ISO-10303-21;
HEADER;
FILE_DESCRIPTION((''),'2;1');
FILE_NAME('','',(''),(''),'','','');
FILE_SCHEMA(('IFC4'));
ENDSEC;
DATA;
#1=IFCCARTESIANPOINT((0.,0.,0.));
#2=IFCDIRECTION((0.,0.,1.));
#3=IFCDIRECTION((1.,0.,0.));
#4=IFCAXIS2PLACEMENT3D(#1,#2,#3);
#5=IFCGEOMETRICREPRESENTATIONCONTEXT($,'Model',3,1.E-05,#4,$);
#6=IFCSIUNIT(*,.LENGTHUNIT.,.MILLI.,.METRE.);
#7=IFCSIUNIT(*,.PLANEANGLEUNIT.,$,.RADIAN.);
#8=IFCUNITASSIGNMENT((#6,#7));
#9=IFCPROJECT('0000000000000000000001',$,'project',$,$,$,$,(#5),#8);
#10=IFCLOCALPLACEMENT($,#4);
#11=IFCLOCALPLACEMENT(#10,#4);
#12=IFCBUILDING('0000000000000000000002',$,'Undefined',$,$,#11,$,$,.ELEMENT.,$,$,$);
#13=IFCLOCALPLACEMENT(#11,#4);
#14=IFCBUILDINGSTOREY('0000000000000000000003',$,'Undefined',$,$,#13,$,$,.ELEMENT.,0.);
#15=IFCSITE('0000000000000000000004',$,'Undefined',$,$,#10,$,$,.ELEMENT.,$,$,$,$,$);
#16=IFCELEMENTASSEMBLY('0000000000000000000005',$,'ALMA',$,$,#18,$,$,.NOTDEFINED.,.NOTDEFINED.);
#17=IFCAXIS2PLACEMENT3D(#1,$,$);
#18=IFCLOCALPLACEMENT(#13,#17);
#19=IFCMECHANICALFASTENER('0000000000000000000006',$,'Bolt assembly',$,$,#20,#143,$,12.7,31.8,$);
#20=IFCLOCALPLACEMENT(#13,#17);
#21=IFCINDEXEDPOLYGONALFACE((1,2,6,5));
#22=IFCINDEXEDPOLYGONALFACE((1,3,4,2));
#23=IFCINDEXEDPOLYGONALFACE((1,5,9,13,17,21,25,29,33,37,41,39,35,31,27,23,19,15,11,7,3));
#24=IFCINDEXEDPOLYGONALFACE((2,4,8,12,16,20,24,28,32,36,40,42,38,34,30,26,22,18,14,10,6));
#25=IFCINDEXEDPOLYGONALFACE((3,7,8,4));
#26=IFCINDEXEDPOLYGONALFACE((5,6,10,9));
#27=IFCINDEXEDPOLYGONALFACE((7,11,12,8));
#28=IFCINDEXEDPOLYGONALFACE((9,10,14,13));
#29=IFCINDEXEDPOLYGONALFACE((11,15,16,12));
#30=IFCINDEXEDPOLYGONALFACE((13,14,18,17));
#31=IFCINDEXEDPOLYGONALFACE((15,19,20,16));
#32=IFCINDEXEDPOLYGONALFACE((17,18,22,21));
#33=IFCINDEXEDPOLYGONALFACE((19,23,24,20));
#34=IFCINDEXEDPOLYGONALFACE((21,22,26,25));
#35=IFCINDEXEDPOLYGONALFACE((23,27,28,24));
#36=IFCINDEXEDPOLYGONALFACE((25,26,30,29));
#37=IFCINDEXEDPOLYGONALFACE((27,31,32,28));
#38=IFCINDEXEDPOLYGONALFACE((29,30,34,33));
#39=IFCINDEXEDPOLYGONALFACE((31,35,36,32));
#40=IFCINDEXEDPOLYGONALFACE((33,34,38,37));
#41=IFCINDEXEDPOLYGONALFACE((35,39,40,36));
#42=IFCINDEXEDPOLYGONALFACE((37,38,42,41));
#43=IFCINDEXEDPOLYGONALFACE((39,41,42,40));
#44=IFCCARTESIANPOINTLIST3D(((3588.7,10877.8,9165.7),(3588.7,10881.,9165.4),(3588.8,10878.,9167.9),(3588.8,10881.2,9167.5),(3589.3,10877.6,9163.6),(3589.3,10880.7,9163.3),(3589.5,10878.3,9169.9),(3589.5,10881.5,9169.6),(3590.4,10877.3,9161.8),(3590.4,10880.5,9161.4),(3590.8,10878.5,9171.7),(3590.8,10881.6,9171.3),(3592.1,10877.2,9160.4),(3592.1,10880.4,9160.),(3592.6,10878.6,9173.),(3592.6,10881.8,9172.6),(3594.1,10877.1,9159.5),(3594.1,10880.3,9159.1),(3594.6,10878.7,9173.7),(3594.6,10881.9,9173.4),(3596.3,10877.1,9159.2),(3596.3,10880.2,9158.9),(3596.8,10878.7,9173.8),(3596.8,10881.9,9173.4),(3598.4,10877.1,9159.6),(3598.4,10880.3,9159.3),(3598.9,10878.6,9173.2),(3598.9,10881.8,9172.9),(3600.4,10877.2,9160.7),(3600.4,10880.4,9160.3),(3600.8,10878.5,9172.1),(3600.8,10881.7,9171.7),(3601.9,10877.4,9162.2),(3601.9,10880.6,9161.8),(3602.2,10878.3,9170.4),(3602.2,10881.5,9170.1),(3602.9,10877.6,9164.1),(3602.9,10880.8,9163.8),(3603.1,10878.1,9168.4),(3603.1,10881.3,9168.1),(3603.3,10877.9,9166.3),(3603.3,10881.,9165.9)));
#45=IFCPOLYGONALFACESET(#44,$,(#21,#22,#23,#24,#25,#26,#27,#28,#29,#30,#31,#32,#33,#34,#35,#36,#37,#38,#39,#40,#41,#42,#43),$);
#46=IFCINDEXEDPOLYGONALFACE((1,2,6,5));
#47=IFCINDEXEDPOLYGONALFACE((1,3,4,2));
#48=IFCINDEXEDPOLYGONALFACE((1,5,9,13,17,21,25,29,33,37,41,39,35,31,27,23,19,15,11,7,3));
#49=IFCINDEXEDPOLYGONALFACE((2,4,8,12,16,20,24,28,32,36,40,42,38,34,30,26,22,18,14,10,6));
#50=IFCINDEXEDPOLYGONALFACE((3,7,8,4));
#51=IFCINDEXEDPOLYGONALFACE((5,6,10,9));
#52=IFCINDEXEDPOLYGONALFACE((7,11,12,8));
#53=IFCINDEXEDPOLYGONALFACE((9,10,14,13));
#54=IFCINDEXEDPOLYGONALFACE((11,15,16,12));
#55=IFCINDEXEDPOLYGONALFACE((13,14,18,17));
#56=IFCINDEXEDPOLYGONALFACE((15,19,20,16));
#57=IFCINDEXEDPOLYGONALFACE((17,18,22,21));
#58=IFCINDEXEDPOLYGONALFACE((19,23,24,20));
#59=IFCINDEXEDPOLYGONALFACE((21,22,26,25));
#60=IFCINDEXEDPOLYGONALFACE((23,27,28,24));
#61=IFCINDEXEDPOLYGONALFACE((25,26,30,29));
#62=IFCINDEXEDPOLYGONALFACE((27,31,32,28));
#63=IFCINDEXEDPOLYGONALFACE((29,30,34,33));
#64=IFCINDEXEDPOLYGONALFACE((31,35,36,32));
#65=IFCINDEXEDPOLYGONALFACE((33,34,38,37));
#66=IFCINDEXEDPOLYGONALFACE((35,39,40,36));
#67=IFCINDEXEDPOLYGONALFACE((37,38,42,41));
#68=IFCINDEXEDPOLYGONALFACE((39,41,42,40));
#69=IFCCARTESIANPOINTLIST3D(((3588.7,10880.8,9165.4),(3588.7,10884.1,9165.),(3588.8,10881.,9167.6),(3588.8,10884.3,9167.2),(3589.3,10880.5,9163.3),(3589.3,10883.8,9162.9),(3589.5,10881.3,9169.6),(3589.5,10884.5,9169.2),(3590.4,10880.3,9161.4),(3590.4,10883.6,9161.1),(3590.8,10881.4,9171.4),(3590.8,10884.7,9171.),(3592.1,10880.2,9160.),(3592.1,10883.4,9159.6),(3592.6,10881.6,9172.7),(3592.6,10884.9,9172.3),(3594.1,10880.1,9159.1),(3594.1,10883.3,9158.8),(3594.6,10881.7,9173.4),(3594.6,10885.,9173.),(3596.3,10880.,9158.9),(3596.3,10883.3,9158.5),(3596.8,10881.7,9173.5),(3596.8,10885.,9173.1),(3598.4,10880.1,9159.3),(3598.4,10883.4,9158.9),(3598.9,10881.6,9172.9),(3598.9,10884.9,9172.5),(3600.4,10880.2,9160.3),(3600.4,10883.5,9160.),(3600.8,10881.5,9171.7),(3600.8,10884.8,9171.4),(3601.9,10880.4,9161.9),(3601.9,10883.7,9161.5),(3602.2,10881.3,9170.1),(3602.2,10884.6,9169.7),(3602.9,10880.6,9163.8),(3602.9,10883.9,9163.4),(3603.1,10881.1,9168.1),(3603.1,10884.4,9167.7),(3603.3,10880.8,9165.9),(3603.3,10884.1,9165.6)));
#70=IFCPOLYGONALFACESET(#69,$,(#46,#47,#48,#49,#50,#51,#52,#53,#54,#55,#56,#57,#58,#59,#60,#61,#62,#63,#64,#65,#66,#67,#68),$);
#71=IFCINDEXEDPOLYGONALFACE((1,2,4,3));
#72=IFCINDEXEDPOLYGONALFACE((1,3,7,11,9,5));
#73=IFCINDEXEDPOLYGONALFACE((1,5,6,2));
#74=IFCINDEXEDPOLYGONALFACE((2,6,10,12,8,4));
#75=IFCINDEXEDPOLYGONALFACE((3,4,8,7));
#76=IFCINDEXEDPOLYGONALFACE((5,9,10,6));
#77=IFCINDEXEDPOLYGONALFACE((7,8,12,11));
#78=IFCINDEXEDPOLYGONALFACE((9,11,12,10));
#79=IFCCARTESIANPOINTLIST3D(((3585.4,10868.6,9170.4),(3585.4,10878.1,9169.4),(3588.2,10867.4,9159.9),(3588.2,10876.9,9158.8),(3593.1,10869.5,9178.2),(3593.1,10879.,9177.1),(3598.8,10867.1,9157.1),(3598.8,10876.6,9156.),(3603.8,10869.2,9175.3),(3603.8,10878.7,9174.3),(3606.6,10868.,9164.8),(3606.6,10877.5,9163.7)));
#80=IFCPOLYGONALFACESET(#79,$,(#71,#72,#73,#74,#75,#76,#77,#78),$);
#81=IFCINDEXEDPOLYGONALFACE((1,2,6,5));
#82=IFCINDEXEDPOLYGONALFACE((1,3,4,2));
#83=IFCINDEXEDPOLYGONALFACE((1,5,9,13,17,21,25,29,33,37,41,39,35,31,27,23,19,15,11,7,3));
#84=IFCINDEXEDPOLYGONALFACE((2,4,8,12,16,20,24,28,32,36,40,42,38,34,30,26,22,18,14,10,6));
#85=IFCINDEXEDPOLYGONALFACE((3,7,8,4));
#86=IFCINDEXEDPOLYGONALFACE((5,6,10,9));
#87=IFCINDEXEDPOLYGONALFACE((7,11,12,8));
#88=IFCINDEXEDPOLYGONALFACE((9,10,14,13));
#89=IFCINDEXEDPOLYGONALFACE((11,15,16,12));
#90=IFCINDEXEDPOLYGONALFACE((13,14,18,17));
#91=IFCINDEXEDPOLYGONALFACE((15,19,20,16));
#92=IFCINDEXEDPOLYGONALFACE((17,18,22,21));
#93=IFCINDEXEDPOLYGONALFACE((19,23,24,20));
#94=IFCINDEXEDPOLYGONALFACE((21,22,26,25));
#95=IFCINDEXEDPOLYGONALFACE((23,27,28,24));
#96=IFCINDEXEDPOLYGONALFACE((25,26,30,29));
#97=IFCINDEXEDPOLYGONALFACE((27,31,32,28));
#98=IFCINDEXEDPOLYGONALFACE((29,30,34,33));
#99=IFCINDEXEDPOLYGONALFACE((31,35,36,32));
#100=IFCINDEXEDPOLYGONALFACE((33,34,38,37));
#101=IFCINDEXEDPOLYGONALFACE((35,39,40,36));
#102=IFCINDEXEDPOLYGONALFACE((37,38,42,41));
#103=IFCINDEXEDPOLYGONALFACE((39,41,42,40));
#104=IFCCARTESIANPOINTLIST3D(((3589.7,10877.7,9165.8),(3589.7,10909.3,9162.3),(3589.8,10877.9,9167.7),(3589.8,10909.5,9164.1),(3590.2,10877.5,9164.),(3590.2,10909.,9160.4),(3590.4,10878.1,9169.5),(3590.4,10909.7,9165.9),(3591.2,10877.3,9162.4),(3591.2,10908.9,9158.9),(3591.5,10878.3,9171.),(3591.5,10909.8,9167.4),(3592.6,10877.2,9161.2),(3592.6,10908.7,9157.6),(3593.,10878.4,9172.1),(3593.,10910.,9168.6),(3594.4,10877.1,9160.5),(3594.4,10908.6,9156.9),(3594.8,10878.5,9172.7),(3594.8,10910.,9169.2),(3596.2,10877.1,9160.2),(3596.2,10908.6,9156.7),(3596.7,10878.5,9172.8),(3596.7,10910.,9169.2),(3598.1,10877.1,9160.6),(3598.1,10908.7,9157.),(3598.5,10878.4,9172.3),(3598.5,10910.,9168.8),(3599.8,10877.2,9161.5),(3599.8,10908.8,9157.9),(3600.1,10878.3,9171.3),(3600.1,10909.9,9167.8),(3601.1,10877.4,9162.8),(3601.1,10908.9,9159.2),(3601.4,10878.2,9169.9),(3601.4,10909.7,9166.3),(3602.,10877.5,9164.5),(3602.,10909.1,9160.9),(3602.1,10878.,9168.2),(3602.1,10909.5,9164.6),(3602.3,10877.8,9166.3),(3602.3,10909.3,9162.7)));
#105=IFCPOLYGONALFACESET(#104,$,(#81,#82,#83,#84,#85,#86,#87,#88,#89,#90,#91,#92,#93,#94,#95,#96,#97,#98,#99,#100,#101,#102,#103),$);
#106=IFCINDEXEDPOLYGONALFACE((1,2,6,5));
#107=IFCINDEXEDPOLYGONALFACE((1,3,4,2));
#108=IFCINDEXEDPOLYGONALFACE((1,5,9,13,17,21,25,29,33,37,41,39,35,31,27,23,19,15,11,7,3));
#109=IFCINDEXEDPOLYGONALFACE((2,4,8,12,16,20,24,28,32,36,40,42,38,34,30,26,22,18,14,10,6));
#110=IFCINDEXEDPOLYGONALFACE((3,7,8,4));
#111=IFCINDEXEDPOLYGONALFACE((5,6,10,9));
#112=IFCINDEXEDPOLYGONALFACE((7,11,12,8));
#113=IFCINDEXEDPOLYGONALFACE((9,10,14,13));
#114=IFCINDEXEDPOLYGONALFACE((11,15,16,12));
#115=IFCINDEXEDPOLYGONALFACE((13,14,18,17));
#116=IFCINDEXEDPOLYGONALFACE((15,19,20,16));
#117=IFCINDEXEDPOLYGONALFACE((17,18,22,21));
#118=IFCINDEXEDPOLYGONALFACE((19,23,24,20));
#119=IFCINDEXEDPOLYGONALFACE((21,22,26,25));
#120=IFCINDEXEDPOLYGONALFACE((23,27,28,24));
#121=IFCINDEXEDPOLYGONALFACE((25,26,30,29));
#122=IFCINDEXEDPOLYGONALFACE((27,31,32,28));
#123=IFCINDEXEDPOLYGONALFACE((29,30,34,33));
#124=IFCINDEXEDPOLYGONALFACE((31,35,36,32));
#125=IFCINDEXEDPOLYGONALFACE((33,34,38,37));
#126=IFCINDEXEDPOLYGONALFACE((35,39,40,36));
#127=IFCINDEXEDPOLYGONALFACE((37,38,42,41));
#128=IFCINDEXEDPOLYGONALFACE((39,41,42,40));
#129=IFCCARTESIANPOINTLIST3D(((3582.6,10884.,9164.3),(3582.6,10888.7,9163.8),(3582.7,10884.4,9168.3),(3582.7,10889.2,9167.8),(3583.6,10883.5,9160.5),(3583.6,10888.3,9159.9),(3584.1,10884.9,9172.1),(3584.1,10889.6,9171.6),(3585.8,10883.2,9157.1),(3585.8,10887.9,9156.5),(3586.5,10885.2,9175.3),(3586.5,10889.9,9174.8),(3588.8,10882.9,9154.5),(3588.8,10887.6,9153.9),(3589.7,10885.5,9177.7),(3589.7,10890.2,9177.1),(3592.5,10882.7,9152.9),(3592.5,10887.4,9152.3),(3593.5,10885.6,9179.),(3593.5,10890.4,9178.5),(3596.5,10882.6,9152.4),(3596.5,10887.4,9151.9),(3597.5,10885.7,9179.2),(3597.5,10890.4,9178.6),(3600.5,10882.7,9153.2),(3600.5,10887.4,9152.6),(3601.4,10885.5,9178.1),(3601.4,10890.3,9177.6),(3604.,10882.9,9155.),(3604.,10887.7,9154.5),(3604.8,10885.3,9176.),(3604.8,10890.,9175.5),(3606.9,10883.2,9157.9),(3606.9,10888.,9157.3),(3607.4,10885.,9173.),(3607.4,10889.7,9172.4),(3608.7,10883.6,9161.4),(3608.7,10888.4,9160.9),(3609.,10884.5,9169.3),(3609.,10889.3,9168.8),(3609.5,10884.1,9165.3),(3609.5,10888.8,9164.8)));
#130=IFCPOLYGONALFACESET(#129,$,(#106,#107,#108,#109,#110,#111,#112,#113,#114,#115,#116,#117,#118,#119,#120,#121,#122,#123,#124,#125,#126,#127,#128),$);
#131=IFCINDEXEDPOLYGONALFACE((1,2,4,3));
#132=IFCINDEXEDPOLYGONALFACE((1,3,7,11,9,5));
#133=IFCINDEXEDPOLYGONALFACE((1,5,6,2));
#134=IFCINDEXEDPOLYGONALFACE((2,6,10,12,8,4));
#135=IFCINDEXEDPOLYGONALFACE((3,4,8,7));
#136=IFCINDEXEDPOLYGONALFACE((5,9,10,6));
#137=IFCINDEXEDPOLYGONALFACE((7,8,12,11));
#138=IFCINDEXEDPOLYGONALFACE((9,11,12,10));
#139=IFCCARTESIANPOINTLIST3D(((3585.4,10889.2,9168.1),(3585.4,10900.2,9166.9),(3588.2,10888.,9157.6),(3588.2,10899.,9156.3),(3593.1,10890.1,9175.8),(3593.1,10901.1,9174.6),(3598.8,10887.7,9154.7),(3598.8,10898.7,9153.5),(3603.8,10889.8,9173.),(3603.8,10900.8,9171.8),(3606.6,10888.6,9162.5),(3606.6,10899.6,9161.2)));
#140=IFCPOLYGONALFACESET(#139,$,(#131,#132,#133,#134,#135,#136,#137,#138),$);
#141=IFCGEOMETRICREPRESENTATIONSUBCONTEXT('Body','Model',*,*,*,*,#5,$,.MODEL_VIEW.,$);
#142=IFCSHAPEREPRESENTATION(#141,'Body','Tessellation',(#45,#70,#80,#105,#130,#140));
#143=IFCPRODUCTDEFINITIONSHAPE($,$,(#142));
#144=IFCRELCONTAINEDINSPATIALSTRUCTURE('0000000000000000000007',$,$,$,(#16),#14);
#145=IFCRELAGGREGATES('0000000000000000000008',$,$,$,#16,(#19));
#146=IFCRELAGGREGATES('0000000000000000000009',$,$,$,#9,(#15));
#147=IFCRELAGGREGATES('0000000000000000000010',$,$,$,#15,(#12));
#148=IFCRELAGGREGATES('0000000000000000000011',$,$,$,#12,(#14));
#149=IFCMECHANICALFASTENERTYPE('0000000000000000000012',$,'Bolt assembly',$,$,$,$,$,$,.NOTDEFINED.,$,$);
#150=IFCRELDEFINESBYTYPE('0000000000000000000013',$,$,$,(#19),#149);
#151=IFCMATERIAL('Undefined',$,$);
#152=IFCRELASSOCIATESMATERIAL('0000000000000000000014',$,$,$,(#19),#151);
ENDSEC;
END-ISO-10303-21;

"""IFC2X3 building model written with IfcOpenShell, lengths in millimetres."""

from ifc_helpers import new_model, si_unit, frame, origin_with_axes, origin_2d_with_axis, place, context, subcontext, project, spatial, polyline, circle, outline, extrude, source, transform, mapped, material, type_object, element, aggregate, save


model = new_model("IFC2X3")

# Units and contexts
model_context = context("Model", 3, precision=1e-05, world=origin_with_axes())
body_context = subcontext(model_context, "Body", "Model", "MODEL_VIEW")
ifc_project = project(units=[si_unit("LENGTHUNIT", "METRE", prefix="MILLI"), si_unit("PLANEANGLEUNIT", "RADIAN")], contexts=[model_context])

# Site, building, storey
site_placement = place(None, origin_with_axes())
site = spatial("IfcSite", under=ifc_project, at=site_placement, Name="Undefined", CompositionType="ELEMENT")
building_placement = place(site_placement, origin_with_axes())
building = spatial("IfcBuilding", under=site, at=building_placement, Name="Undefined", CompositionType="ELEMENT")
storey_placement = place(building_placement, origin_with_axes())
storey = spatial("IfcBuildingStorey", under=building, at=storey_placement, Name="Undefined", CompositionType="ELEMENT", Elevation=0.0)

# Element assembly
assembly_1_placement = place(storey_placement, origin_with_axes())
assembly_1 = element("IfcElementAssembly", 1, at=assembly_1_placement, inside=storey, Name="ALMA", AssemblyPlace="NOTDEFINED", PredefinedType="NOTDEFINED")

# Mechanical fastener
ifc_material_1 = material(Name="Undefined")
mechanical_fastener_type = type_object("IfcMechanicalFastenerType", Name="Bolt assembly")
shared_shape_1 = source(origin_with_axes(), body_context, "Body", "SweptSolid", [
    extrude(circle(Radius=7.3, at=origin_2d_with_axis()), frame((0.0, 0.1, 0.0), z_axis=(0.0, 1.0, 0.0), x_axis=(1.0, 0.0, 0.0)), (0.0, 0.0, 1.0), 3.2),
    extrude(circle(Radius=7.3, at=origin_2d_with_axis()), frame((0.0, 3.1, 0.0), z_axis=(0.0, 1.0, 0.0), x_axis=(1.0, 0.0, 0.0)), (0.0, 0.0, 1.0), 3.3),
    extrude(outline(polyline([(9.5, -5.5), (9.5, 5.5), (0.0, 11.0), (-9.5, 5.5), (-9.5, -5.5), (0.0, -11.0), (9.5, -5.5)])), frame((0.0, -9.5, 0.0), z_axis=(0.0, 1.0, 0.0), x_axis=(1.0, 0.0, 0.0)), (0.0, 0.0, 1.0), 9.5),
    extrude(circle(Radius=6.3, at=origin_2d_with_axis()), frame((0.0, 0.0, 0.0), z_axis=(0.0, 1.0, 0.0), x_axis=(1.0, 0.0, 0.0)), (0.0, 0.0, 1.0), 31.8),
    extrude(circle(Radius=13.5, at=origin_2d_with_axis()), frame((0.0, 6.4, 0.0), z_axis=(0.0, 1.0, 0.0), x_axis=(1.0, 0.0, 0.0)), (0.0, 0.0, 1.0), 4.8),
    extrude(outline(polyline([(9.5, -5.5), (9.5, 5.5), (0.0, 11.0), (-9.5, 5.5), (-9.5, -5.5), (0.0, -11.0), (9.5, -5.5)])), frame((0.0, 11.2, 0.0), z_axis=(0.0, 1.0, 0.0), x_axis=(1.0, 0.0, 0.0)), (0.0, 0.0, 1.0), 11.1),
])
mechanical_fastener_1_placement = place(assembly_1_placement, frame((3596.0, 10877.8, 9166.5), z_axis=(-0.707107, -0.079651, -0.702606), x_axis=(-0.707107, 0.079651, 0.702606)))
mechanical_fastener_1 = element("IfcMechanicalFastener", 2, at=mechanical_fastener_1_placement, type_object=mechanical_fastener_type, material=ifc_material_1, Name="Bolt assembly", NominalDiameter=12.7, NominalLength=31.8, context=body_context, shape_type="MappedRepresentation", body=[
    mapped(shared_shape_1, transform((0.0, 0.0, 0.0))),
])

aggregate(assembly_1, [mechanical_fastener_1])

save(model, "model.ifc")
